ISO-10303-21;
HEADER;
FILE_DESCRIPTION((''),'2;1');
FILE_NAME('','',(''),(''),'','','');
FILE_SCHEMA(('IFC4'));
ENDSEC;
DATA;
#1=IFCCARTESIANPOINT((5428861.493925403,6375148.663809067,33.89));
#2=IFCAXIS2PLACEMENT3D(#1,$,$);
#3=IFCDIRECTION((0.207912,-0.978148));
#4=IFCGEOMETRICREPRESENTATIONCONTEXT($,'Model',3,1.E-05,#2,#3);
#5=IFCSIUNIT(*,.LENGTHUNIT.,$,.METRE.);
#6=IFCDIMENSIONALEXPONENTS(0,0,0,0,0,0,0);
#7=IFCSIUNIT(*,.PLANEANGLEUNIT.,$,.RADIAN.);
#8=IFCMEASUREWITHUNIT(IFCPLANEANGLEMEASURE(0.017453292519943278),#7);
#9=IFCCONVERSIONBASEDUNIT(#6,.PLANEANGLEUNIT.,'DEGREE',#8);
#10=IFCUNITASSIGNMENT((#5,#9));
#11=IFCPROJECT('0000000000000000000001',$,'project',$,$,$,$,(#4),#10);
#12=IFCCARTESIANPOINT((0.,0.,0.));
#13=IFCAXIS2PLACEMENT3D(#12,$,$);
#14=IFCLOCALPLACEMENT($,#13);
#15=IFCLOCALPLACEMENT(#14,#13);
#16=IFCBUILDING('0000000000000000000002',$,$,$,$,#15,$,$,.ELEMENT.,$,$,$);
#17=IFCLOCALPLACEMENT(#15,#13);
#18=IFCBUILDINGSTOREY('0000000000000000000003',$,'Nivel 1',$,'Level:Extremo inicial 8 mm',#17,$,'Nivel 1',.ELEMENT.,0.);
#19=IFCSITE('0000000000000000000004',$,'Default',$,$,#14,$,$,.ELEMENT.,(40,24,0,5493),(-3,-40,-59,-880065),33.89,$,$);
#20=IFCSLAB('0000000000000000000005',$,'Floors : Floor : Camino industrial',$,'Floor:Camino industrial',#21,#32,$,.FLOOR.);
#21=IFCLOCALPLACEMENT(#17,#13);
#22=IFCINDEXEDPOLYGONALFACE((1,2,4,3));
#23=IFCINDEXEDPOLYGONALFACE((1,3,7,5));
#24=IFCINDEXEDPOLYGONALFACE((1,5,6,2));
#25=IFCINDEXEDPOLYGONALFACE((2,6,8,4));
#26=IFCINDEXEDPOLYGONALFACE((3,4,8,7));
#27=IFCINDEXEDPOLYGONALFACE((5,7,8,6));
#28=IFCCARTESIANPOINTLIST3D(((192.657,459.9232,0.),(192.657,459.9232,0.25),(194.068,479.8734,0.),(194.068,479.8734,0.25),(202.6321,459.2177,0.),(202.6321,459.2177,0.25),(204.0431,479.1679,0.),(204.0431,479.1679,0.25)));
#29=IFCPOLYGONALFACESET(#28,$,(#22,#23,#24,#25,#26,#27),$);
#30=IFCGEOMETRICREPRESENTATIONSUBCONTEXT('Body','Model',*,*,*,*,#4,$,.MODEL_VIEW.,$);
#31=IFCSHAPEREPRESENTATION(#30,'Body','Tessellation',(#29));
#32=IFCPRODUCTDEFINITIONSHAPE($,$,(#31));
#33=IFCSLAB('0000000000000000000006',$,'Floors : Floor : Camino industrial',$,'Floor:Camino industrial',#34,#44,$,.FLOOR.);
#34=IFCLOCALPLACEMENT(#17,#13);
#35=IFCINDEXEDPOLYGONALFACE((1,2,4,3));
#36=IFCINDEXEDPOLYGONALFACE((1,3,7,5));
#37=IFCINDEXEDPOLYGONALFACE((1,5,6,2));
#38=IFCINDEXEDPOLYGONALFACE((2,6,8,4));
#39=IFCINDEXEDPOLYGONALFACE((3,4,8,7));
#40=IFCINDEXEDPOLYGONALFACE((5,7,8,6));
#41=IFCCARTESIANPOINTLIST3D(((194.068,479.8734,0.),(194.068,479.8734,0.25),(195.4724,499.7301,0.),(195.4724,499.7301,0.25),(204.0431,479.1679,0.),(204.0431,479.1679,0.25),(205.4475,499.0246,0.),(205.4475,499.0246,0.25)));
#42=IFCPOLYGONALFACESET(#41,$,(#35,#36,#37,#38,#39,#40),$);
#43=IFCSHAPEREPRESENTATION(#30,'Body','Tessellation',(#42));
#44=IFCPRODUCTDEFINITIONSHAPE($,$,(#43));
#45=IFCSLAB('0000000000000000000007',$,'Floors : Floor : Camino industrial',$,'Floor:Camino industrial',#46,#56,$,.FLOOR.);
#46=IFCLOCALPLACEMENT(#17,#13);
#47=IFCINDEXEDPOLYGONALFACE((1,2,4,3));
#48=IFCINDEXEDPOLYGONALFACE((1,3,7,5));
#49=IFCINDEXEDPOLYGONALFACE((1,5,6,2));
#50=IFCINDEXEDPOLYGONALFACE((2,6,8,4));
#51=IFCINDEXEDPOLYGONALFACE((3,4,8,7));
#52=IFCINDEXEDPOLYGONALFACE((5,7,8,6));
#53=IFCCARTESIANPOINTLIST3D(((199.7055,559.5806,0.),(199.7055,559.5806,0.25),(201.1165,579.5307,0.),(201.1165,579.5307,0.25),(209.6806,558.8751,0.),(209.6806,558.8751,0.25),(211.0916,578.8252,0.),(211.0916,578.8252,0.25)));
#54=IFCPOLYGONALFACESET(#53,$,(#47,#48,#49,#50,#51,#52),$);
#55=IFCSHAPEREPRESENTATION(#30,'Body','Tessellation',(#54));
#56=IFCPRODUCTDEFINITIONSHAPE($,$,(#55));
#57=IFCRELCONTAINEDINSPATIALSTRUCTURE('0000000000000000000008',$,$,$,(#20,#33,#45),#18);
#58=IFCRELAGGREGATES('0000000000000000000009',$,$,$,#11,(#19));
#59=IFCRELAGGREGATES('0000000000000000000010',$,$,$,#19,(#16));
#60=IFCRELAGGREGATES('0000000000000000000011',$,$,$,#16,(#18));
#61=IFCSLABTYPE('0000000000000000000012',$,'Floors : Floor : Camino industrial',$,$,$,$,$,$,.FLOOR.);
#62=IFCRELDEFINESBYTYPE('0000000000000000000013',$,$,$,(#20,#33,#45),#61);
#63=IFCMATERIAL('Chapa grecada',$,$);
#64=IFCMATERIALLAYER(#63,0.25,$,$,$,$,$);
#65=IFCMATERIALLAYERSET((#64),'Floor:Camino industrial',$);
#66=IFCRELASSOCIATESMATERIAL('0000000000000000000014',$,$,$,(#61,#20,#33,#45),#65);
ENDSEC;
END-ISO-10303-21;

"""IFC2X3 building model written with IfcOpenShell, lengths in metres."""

from ifc_helpers import new_model, entity, si_unit, converted_unit, direction, frame, frame_2d, origin, place, context, subcontext, project, spatial, rectangle, extrude, material, layer, layer_set, layer_usage, type_object, element, save


model = new_model("IFC2X3")

# Units and contexts
model_context = context("Model", 3, precision=1e-05, world=frame((5428861.493925403, 6375148.663809067, 33.89)), true_north=direction((0.207912, -0.978148)))
body_context = subcontext(model_context, "Body", "Model", "MODEL_VIEW")
ifc_project = project(units=[si_unit("LENGTHUNIT", "METRE"), converted_unit("PLANEANGLEUNIT", "DEGREE", entity("IfcPlaneAngleMeasure", 0.017453292519943278), si_unit("PLANEANGLEUNIT", "RADIAN"), dimensions=[0, 0, 0, 0, 0, 0, 0])], contexts=[model_context])

# Site, building, storey
site_placement = place(None, origin())
site = spatial("IfcSite", under=ifc_project, at=site_placement, Name="Default", CompositionType="ELEMENT", RefLatitude=(40, 24, 0, 5493), RefLongitude=(-3, -40, -59, -880065), RefElevation=33.89)
building_placement = place(site_placement, origin())
building = spatial("IfcBuilding", under=site, at=building_placement, CompositionType="ELEMENT")
storey_placement = place(building_placement, origin())
storey = spatial("IfcBuildingStorey", under=building, at=storey_placement, Name="Nivel 1", ObjectType="Level:Extremo inicial 8 mm", LongName="Nivel 1", CompositionType="ELEMENT", Elevation=0.0)

# Slabs
ifc_material = material(Name="Chapa grecada")
ifc_layer = layer(ifc_material, 0.25)
ifc_layer_set = layer_set([ifc_layer], Name="Floor:Camino industrial")
slab_type = type_object("IfcSlabType", Name="Floors : Floor : Camino industrial", PredefinedType="FLOOR", material=ifc_layer_set)
ifc_layer_usage_1 = layer_usage(ifc_layer_set, "AXIS3", "POSITIVE", 0.0)
slab_1_placement = place(storey_placement, origin())
element("IfcSlab", 1, at=slab_1_placement, inside=storey, type_object=slab_type, material=ifc_layer_usage_1, Name="Floors : Floor : Camino industrial", ObjectType="Floor:Camino industrial", PredefinedType="FLOOR", context=body_context, shape_type="SweptSolid", body=[
    extrude(rectangle(XDim=20.0, YDim=10.0, at=frame_2d((0.0, 0.0), x_axis=(1.0, 0.0))), frame((198.3501, 469.5455, 0.25), z_axis=(0.0, 0.0, -1.0), x_axis=(-0.070551, -0.997508, 0.0)), (0.0, 0.0, 1.0), 0.25),
])
ifc_layer_usage_2 = layer_usage(ifc_layer_set, "AXIS3", "POSITIVE", 0.0)
slab_2_placement = place(storey_placement, origin())
element("IfcSlab", 2, at=slab_2_placement, inside=storey, type_object=slab_type, material=ifc_layer_usage_2, Name="Floors : Floor : Camino industrial", ObjectType="Floor:Camino industrial", PredefinedType="FLOOR", context=body_context, shape_type="SweptSolid", body=[
    extrude(rectangle(XDim=19.9063, YDim=10.0, at=frame_2d((0.0, 0.0), x_axis=(1.0, 0.0))), frame((199.7578, 489.449, 0.25), z_axis=(0.0, 0.0, -1.0), x_axis=(-0.070551, -0.997508, 0.0)), (0.0, 0.0, 1.0), 0.25),
])
ifc_layer_usage_3 = layer_usage(ifc_layer_set, "AXIS3", "POSITIVE", 0.0)
slab_3_placement = place(storey_placement, origin())
element("IfcSlab", 3, at=slab_3_placement, inside=storey, type_object=slab_type, material=ifc_layer_usage_3, Name="Floors : Floor : Camino industrial", ObjectType="Floor:Camino industrial", PredefinedType="FLOOR", context=body_context, shape_type="SweptSolid", body=[
    extrude(rectangle(XDim=20.0, YDim=10.0, at=frame_2d((0.0, 0.0), x_axis=(1.0, 0.0))), frame((205.3986, 569.2029, 0.25), z_axis=(0.0, 0.0, -1.0), x_axis=(-0.070551, -0.997508, 0.0)), (0.0, 0.0, 1.0), 0.25),
])

save(model, "model.ifc")
